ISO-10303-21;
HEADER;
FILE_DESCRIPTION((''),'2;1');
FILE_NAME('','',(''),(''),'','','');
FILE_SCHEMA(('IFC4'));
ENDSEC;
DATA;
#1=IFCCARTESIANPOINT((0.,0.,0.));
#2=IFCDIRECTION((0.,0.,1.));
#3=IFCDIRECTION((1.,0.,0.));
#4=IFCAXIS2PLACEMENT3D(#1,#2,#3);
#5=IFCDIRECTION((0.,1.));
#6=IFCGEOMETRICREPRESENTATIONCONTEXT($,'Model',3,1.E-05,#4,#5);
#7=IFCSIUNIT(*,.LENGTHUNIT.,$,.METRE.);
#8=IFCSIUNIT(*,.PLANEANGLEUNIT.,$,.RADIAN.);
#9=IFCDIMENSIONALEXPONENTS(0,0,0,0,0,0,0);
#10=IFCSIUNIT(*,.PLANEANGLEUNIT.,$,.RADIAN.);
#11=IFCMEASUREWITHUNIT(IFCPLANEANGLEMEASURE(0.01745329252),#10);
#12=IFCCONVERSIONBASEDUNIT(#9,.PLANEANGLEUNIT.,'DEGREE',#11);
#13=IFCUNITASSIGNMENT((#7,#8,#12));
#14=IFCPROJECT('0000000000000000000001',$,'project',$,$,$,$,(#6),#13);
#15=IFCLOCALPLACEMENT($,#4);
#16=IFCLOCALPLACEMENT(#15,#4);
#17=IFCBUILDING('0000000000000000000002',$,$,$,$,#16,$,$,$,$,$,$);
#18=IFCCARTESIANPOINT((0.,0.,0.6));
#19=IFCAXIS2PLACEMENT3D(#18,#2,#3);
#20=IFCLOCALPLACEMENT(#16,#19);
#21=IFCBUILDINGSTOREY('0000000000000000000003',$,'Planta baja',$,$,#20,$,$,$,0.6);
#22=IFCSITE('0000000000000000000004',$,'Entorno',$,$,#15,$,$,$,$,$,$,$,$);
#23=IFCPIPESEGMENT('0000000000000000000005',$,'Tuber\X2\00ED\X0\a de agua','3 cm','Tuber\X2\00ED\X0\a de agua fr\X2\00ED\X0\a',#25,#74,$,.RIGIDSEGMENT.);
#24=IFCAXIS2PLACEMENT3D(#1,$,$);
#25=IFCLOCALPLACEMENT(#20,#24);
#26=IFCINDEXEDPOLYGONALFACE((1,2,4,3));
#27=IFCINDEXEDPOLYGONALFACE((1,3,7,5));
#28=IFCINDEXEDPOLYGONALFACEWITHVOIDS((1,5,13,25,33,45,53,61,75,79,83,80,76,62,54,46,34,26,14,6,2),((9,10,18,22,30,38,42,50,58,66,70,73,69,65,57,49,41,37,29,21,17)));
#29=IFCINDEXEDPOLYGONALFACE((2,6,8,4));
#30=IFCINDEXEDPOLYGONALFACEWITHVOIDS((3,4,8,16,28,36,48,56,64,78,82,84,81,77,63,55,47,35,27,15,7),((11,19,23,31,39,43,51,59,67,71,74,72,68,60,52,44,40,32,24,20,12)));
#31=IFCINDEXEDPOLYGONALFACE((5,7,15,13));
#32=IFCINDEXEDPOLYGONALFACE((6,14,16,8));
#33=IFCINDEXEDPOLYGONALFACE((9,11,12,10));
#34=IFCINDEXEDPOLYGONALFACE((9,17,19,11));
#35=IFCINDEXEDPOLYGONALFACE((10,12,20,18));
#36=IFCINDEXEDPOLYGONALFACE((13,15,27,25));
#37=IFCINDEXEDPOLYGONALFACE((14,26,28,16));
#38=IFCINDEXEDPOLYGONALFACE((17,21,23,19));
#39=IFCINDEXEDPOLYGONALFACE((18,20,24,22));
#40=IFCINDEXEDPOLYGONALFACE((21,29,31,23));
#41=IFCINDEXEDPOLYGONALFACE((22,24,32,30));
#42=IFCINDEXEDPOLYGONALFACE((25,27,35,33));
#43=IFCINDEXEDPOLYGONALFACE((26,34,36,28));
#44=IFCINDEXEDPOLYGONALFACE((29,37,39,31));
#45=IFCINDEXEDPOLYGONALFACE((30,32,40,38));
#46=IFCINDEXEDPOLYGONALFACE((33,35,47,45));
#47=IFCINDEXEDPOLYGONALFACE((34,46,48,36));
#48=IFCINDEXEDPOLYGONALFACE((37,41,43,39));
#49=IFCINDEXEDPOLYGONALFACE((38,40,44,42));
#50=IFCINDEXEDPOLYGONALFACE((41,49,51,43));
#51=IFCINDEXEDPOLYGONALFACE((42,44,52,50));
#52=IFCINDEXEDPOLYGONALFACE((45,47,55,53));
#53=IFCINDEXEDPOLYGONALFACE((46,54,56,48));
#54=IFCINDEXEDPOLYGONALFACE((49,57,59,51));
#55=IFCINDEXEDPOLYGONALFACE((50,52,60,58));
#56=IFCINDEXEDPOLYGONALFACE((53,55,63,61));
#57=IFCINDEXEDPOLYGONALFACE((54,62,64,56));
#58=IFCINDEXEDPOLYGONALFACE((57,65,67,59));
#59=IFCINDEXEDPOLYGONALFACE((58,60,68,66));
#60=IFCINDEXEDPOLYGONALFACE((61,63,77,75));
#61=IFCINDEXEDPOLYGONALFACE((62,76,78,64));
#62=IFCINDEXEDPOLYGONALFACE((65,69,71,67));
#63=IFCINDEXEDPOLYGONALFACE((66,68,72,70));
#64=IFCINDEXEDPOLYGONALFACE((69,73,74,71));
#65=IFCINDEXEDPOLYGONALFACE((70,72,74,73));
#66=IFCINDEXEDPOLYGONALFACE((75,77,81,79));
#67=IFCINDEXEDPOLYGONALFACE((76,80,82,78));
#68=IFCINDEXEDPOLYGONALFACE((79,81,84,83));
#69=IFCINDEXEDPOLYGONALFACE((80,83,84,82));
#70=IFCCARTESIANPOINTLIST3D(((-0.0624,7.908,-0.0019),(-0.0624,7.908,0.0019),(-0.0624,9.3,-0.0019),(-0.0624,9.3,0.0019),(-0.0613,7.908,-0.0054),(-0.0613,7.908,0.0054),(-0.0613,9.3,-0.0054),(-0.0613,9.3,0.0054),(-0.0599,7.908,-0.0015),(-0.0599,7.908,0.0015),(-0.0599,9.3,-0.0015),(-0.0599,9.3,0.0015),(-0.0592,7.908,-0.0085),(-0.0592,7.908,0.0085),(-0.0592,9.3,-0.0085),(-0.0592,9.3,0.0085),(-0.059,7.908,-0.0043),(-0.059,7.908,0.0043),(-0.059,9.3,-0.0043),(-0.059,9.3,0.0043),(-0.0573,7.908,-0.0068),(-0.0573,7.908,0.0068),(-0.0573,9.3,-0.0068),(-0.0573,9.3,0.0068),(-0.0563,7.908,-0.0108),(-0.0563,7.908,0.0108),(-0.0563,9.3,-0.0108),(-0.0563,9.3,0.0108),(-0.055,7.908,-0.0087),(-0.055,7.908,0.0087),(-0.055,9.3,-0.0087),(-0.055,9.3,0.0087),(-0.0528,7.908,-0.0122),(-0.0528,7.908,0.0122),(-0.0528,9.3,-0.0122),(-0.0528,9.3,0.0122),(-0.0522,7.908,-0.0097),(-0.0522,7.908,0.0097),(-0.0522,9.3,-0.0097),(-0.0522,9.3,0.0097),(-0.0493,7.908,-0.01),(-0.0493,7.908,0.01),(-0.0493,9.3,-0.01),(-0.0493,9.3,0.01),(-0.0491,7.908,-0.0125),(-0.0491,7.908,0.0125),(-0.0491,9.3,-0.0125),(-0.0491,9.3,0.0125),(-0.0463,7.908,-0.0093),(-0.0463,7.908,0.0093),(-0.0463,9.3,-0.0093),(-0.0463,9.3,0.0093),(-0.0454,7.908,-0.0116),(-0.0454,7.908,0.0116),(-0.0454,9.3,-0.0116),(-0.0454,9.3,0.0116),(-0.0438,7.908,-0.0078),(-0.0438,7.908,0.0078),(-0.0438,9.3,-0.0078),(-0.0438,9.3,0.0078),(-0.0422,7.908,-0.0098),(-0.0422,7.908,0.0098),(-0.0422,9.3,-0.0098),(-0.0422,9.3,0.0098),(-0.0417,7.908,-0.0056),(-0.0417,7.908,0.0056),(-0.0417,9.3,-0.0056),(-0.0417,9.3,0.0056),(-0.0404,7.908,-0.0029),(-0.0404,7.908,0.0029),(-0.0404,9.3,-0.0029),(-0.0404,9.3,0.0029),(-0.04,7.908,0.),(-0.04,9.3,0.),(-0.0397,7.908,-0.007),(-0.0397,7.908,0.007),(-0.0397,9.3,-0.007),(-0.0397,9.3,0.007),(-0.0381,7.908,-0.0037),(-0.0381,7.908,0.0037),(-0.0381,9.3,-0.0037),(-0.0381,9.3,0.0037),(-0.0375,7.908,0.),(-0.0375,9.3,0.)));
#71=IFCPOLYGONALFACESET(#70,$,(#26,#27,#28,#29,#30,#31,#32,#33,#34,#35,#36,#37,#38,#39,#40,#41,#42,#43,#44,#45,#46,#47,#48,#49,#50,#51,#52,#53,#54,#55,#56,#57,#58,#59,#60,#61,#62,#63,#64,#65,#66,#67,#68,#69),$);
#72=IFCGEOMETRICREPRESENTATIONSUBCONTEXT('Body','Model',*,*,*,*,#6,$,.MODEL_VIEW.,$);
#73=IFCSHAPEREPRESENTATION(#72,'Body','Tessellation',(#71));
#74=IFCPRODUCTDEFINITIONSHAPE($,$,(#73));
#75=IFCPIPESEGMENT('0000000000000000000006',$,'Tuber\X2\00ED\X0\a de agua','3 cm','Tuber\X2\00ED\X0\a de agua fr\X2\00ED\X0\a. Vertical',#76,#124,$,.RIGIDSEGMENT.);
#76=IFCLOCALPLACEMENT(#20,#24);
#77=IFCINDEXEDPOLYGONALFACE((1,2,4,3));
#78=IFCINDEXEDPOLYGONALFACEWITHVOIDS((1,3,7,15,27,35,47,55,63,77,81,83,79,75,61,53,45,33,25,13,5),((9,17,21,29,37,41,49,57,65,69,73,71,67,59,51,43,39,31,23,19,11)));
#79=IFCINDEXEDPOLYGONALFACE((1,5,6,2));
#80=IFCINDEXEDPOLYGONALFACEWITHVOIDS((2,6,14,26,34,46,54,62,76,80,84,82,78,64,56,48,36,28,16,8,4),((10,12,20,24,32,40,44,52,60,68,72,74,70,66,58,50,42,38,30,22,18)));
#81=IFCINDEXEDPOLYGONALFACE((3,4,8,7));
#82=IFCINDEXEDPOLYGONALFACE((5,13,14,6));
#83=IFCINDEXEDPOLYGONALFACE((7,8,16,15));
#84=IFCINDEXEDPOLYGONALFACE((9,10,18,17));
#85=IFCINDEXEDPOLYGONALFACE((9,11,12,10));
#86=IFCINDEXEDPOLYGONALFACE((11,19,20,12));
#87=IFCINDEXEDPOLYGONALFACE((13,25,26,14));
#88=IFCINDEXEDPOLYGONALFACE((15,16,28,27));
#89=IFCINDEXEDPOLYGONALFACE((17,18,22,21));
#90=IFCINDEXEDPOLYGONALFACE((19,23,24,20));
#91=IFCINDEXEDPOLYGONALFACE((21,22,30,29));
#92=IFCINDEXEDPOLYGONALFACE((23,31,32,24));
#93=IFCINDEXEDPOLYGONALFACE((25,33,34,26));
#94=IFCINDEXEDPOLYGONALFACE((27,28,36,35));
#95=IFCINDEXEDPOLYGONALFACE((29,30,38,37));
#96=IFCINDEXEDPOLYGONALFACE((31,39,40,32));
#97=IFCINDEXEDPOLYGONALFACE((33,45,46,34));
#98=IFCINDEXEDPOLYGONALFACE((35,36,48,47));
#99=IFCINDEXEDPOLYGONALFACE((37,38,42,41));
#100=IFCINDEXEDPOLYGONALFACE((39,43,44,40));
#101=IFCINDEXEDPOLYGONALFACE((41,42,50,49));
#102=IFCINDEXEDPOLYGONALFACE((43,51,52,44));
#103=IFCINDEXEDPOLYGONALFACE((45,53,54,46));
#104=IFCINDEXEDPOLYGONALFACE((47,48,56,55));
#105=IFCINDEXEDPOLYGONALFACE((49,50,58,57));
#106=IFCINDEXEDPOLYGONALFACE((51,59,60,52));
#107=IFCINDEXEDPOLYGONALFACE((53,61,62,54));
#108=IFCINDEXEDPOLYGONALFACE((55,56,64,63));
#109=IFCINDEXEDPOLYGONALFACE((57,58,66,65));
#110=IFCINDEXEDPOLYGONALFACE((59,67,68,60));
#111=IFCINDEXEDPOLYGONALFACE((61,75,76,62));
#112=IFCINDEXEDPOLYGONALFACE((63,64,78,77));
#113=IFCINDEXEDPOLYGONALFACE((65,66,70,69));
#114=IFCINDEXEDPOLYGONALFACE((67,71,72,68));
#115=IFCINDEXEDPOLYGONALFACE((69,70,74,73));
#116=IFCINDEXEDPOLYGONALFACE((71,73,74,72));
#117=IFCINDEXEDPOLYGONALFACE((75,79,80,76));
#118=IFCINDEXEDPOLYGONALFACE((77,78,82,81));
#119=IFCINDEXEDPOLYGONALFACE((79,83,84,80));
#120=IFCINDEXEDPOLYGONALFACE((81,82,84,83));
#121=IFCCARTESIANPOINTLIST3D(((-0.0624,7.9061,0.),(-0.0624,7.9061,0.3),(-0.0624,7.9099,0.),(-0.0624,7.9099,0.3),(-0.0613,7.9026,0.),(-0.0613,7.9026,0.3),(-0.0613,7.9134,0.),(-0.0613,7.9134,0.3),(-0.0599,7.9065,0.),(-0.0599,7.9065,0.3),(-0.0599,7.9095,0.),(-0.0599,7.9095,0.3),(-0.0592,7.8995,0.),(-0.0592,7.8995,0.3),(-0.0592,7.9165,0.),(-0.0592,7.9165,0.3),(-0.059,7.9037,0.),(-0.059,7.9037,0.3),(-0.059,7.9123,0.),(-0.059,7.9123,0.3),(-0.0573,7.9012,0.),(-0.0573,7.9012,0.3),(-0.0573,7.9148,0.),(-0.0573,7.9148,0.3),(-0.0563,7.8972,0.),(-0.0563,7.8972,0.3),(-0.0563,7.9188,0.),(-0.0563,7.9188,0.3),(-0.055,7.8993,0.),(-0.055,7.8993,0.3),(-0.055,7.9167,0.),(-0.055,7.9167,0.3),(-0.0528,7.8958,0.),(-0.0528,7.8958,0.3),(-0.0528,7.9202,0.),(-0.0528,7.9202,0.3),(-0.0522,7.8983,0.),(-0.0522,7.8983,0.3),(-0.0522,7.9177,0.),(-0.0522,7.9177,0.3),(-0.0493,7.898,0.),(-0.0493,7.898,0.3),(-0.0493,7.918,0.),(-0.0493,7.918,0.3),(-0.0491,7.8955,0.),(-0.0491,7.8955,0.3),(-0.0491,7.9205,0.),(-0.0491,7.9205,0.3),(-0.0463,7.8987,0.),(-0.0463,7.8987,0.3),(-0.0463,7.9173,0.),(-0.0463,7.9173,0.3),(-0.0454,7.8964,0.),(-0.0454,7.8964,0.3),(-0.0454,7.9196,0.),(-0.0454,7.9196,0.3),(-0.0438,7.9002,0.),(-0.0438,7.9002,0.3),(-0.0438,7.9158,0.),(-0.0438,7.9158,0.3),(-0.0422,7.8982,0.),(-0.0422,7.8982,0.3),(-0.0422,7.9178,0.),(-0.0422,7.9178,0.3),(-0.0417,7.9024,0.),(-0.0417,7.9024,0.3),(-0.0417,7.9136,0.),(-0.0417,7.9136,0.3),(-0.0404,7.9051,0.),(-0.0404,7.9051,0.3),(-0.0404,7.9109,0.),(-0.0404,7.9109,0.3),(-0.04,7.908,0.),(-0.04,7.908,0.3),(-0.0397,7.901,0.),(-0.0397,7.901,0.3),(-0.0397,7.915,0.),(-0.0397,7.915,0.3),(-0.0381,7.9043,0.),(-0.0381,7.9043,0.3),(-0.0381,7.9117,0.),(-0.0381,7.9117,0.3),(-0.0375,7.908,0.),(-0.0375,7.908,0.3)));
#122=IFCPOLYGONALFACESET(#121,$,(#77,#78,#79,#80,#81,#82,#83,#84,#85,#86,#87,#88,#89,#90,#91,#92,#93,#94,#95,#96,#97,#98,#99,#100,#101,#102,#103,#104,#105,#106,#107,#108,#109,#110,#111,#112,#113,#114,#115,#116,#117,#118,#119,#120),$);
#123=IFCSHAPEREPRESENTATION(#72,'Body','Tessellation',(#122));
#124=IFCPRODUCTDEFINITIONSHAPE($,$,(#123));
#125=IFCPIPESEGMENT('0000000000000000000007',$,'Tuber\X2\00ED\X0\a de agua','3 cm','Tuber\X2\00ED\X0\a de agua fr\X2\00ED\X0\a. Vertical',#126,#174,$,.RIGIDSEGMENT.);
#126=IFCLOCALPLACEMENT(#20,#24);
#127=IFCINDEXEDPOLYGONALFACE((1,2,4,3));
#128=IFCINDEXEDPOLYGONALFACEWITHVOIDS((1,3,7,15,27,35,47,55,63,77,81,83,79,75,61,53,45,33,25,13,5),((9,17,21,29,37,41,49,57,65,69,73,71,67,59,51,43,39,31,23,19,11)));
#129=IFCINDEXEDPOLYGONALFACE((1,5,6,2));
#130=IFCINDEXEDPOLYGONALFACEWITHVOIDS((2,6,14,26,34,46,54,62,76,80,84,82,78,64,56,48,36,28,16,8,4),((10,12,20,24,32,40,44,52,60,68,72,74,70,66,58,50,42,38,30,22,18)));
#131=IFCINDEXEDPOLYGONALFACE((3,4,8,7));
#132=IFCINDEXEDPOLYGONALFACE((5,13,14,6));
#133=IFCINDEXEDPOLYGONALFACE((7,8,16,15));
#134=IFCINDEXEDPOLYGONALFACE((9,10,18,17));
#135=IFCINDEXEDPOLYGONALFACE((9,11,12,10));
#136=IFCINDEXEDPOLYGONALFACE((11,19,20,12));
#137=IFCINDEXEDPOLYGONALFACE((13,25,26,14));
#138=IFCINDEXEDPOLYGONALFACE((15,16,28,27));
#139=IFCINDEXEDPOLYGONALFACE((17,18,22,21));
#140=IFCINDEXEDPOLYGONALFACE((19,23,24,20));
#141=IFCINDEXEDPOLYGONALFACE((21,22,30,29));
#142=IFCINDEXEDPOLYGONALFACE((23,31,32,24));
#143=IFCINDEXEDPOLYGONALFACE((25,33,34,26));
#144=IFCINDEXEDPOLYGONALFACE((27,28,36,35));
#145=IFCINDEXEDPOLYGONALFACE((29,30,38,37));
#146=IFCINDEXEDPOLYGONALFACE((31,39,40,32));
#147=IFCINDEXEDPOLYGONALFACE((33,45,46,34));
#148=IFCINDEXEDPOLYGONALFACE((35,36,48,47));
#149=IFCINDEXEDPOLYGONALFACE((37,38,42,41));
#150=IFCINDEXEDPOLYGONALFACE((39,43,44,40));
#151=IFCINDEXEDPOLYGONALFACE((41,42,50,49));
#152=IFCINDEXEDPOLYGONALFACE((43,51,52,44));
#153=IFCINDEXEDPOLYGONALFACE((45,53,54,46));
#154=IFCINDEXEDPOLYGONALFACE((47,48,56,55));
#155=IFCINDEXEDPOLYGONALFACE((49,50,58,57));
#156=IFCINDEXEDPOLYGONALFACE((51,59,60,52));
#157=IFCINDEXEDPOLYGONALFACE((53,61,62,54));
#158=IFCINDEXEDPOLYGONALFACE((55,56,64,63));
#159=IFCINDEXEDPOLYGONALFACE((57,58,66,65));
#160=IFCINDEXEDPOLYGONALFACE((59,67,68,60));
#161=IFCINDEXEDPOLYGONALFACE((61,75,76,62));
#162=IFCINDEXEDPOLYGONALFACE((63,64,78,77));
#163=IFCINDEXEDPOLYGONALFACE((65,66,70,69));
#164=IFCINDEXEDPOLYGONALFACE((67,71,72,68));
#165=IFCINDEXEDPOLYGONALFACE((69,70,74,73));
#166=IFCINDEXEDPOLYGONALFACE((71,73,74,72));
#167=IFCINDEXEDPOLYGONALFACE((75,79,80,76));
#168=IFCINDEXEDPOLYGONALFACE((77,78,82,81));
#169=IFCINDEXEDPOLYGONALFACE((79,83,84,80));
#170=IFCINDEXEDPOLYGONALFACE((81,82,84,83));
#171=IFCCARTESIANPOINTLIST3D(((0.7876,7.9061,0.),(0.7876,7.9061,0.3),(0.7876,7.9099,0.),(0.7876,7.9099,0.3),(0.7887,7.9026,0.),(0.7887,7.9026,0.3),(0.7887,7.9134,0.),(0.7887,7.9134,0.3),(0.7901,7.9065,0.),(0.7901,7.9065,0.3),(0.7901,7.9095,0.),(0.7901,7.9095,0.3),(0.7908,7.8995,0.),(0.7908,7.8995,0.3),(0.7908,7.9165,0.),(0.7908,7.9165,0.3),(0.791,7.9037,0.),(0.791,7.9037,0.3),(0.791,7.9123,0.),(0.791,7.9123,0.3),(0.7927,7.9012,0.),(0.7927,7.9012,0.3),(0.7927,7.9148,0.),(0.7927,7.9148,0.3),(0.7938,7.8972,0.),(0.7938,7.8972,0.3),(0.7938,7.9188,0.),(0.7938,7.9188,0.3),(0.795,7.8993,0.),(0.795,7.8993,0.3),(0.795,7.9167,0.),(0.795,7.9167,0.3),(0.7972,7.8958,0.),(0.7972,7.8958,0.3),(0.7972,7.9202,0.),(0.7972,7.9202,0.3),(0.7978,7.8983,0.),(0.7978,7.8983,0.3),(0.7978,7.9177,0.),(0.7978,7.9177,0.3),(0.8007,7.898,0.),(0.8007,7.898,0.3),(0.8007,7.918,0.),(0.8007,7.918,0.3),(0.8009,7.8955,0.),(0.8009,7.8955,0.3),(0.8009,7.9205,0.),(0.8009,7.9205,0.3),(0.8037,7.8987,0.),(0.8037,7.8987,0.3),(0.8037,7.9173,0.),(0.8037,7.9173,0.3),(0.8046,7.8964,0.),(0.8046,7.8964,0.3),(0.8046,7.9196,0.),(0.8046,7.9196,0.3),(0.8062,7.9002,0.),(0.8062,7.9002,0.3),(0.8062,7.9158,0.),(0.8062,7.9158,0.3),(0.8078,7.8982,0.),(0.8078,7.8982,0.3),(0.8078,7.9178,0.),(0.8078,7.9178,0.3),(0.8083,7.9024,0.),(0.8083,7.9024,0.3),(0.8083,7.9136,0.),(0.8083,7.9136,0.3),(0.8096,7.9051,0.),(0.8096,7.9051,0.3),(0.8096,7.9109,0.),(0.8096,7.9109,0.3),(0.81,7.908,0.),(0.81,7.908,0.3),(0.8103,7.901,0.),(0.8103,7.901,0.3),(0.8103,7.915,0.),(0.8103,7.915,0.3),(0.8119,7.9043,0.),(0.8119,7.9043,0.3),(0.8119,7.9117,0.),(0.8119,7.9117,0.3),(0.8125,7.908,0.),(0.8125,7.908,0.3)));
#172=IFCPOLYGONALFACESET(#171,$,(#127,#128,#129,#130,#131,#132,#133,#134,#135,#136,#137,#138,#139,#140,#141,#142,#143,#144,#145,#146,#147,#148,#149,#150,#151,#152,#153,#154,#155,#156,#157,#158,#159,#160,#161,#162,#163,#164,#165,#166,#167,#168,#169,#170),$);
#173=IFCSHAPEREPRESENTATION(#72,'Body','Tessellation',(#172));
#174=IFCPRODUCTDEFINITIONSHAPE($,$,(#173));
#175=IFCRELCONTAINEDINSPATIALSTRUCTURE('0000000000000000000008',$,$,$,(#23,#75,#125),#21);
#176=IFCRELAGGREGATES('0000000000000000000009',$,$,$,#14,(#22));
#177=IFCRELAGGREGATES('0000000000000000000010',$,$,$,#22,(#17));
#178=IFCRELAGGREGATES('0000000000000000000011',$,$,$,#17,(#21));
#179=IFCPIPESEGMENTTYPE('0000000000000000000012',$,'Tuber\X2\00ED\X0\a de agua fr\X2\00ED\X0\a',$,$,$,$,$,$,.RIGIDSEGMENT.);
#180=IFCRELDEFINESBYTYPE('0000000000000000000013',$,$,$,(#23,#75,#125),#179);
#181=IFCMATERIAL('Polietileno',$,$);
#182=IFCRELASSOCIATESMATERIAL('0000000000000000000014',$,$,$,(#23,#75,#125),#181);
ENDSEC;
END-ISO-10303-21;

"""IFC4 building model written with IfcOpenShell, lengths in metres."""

from ifc_helpers import new_model, entity, si_unit, converted_unit, direction, frame, origin_with_axes, origin_2d_with_axis, place, context, subcontext, project, spatial, hollow_circle, extrude, material, type_object, element, save


model = new_model("IFC4")

# Units and contexts
model_context = context("Model", 3, precision=1e-05, world=origin_with_axes(), true_north=direction((0.0, 1.0)))
body_context = subcontext(model_context, "Body", "Model", "MODEL_VIEW")
ifc_project = project(units=[si_unit("LENGTHUNIT", "METRE"), si_unit("PLANEANGLEUNIT", "RADIAN"), converted_unit("PLANEANGLEUNIT", "DEGREE", entity("IfcPlaneAngleMeasure", 0.01745329252), si_unit("PLANEANGLEUNIT", "RADIAN"), dimensions=[0, 0, 0, 0, 0, 0, 0])], contexts=[model_context])

# Site, building, storey
site_placement = place(None, origin_with_axes())
site = spatial("IfcSite", under=ifc_project, at=site_placement, Name="Entorno")
building_placement = place(site_placement, origin_with_axes())
building = spatial("IfcBuilding", under=site, at=building_placement)
storey_placement = place(building_placement, frame((0.0, 0.0, 0.6), z_axis=(0.0, 0.0, 1.0), x_axis=(1.0, 0.0, 0.0)))
storey = spatial("IfcBuildingStorey", under=building, at=storey_placement, Name="Planta baja", Elevation=0.6)

# Pipe segments
ifc_material_1 = material(Name="Polietileno")
pipe_segment_type_1 = type_object("IfcPipeSegmentType", Name="Tubería de agua fría", PredefinedType="RIGIDSEGMENT")
pipe_segment_1_placement = place(storey_placement, frame((-0.05, 9.3, 0.0), z_axis=(0.0, -1.0, 0.0), x_axis=(1.0, 0.0, 0.0)))
element("IfcPipeSegment", 1, at=pipe_segment_1_placement, inside=storey, type_object=pipe_segment_type_1, material=ifc_material_1, Name="Tubería de agua", Description="3 cm", ObjectType="Tubería de agua fría", PredefinedType="RIGIDSEGMENT", context=body_context, shape_type="SweptSolid", body=[
    extrude(hollow_circle(Radius=0.0125, WallThickness=0.0025, at=origin_2d_with_axis()), origin_with_axes(), (0.0, 0.0, 1.0), 1.392),
])
for number, where, z_axis, x_axis, name in (
    (2, (-0.05, 7.908, 0.0), (0.0, 0.0, 1.0), (1.0, 0.0, 0.0), "Tubería de agua"),
    (3, (0.8, 7.908, 0.0), (0.0, 0.0, 1.0), (1.0, 0.0, 0.0), "Tubería de agua"),
):
    element("IfcPipeSegment", number, at=place(storey_placement, frame(where, z_axis=z_axis, x_axis=x_axis)), inside=storey, type_object=pipe_segment_type_1, material=ifc_material_1, Name=name, Description="3 cm", ObjectType="Tubería de agua fría. Vertical", PredefinedType="RIGIDSEGMENT", context=body_context, shape_type="SweptSolid", body=[
        extrude(hollow_circle(Radius=0.0125, WallThickness=0.0025, at=origin_2d_with_axis()), origin_with_axes(), (0.0, 0.0, 1.0), 0.3),
    ])

save(model, "model.ifc")
